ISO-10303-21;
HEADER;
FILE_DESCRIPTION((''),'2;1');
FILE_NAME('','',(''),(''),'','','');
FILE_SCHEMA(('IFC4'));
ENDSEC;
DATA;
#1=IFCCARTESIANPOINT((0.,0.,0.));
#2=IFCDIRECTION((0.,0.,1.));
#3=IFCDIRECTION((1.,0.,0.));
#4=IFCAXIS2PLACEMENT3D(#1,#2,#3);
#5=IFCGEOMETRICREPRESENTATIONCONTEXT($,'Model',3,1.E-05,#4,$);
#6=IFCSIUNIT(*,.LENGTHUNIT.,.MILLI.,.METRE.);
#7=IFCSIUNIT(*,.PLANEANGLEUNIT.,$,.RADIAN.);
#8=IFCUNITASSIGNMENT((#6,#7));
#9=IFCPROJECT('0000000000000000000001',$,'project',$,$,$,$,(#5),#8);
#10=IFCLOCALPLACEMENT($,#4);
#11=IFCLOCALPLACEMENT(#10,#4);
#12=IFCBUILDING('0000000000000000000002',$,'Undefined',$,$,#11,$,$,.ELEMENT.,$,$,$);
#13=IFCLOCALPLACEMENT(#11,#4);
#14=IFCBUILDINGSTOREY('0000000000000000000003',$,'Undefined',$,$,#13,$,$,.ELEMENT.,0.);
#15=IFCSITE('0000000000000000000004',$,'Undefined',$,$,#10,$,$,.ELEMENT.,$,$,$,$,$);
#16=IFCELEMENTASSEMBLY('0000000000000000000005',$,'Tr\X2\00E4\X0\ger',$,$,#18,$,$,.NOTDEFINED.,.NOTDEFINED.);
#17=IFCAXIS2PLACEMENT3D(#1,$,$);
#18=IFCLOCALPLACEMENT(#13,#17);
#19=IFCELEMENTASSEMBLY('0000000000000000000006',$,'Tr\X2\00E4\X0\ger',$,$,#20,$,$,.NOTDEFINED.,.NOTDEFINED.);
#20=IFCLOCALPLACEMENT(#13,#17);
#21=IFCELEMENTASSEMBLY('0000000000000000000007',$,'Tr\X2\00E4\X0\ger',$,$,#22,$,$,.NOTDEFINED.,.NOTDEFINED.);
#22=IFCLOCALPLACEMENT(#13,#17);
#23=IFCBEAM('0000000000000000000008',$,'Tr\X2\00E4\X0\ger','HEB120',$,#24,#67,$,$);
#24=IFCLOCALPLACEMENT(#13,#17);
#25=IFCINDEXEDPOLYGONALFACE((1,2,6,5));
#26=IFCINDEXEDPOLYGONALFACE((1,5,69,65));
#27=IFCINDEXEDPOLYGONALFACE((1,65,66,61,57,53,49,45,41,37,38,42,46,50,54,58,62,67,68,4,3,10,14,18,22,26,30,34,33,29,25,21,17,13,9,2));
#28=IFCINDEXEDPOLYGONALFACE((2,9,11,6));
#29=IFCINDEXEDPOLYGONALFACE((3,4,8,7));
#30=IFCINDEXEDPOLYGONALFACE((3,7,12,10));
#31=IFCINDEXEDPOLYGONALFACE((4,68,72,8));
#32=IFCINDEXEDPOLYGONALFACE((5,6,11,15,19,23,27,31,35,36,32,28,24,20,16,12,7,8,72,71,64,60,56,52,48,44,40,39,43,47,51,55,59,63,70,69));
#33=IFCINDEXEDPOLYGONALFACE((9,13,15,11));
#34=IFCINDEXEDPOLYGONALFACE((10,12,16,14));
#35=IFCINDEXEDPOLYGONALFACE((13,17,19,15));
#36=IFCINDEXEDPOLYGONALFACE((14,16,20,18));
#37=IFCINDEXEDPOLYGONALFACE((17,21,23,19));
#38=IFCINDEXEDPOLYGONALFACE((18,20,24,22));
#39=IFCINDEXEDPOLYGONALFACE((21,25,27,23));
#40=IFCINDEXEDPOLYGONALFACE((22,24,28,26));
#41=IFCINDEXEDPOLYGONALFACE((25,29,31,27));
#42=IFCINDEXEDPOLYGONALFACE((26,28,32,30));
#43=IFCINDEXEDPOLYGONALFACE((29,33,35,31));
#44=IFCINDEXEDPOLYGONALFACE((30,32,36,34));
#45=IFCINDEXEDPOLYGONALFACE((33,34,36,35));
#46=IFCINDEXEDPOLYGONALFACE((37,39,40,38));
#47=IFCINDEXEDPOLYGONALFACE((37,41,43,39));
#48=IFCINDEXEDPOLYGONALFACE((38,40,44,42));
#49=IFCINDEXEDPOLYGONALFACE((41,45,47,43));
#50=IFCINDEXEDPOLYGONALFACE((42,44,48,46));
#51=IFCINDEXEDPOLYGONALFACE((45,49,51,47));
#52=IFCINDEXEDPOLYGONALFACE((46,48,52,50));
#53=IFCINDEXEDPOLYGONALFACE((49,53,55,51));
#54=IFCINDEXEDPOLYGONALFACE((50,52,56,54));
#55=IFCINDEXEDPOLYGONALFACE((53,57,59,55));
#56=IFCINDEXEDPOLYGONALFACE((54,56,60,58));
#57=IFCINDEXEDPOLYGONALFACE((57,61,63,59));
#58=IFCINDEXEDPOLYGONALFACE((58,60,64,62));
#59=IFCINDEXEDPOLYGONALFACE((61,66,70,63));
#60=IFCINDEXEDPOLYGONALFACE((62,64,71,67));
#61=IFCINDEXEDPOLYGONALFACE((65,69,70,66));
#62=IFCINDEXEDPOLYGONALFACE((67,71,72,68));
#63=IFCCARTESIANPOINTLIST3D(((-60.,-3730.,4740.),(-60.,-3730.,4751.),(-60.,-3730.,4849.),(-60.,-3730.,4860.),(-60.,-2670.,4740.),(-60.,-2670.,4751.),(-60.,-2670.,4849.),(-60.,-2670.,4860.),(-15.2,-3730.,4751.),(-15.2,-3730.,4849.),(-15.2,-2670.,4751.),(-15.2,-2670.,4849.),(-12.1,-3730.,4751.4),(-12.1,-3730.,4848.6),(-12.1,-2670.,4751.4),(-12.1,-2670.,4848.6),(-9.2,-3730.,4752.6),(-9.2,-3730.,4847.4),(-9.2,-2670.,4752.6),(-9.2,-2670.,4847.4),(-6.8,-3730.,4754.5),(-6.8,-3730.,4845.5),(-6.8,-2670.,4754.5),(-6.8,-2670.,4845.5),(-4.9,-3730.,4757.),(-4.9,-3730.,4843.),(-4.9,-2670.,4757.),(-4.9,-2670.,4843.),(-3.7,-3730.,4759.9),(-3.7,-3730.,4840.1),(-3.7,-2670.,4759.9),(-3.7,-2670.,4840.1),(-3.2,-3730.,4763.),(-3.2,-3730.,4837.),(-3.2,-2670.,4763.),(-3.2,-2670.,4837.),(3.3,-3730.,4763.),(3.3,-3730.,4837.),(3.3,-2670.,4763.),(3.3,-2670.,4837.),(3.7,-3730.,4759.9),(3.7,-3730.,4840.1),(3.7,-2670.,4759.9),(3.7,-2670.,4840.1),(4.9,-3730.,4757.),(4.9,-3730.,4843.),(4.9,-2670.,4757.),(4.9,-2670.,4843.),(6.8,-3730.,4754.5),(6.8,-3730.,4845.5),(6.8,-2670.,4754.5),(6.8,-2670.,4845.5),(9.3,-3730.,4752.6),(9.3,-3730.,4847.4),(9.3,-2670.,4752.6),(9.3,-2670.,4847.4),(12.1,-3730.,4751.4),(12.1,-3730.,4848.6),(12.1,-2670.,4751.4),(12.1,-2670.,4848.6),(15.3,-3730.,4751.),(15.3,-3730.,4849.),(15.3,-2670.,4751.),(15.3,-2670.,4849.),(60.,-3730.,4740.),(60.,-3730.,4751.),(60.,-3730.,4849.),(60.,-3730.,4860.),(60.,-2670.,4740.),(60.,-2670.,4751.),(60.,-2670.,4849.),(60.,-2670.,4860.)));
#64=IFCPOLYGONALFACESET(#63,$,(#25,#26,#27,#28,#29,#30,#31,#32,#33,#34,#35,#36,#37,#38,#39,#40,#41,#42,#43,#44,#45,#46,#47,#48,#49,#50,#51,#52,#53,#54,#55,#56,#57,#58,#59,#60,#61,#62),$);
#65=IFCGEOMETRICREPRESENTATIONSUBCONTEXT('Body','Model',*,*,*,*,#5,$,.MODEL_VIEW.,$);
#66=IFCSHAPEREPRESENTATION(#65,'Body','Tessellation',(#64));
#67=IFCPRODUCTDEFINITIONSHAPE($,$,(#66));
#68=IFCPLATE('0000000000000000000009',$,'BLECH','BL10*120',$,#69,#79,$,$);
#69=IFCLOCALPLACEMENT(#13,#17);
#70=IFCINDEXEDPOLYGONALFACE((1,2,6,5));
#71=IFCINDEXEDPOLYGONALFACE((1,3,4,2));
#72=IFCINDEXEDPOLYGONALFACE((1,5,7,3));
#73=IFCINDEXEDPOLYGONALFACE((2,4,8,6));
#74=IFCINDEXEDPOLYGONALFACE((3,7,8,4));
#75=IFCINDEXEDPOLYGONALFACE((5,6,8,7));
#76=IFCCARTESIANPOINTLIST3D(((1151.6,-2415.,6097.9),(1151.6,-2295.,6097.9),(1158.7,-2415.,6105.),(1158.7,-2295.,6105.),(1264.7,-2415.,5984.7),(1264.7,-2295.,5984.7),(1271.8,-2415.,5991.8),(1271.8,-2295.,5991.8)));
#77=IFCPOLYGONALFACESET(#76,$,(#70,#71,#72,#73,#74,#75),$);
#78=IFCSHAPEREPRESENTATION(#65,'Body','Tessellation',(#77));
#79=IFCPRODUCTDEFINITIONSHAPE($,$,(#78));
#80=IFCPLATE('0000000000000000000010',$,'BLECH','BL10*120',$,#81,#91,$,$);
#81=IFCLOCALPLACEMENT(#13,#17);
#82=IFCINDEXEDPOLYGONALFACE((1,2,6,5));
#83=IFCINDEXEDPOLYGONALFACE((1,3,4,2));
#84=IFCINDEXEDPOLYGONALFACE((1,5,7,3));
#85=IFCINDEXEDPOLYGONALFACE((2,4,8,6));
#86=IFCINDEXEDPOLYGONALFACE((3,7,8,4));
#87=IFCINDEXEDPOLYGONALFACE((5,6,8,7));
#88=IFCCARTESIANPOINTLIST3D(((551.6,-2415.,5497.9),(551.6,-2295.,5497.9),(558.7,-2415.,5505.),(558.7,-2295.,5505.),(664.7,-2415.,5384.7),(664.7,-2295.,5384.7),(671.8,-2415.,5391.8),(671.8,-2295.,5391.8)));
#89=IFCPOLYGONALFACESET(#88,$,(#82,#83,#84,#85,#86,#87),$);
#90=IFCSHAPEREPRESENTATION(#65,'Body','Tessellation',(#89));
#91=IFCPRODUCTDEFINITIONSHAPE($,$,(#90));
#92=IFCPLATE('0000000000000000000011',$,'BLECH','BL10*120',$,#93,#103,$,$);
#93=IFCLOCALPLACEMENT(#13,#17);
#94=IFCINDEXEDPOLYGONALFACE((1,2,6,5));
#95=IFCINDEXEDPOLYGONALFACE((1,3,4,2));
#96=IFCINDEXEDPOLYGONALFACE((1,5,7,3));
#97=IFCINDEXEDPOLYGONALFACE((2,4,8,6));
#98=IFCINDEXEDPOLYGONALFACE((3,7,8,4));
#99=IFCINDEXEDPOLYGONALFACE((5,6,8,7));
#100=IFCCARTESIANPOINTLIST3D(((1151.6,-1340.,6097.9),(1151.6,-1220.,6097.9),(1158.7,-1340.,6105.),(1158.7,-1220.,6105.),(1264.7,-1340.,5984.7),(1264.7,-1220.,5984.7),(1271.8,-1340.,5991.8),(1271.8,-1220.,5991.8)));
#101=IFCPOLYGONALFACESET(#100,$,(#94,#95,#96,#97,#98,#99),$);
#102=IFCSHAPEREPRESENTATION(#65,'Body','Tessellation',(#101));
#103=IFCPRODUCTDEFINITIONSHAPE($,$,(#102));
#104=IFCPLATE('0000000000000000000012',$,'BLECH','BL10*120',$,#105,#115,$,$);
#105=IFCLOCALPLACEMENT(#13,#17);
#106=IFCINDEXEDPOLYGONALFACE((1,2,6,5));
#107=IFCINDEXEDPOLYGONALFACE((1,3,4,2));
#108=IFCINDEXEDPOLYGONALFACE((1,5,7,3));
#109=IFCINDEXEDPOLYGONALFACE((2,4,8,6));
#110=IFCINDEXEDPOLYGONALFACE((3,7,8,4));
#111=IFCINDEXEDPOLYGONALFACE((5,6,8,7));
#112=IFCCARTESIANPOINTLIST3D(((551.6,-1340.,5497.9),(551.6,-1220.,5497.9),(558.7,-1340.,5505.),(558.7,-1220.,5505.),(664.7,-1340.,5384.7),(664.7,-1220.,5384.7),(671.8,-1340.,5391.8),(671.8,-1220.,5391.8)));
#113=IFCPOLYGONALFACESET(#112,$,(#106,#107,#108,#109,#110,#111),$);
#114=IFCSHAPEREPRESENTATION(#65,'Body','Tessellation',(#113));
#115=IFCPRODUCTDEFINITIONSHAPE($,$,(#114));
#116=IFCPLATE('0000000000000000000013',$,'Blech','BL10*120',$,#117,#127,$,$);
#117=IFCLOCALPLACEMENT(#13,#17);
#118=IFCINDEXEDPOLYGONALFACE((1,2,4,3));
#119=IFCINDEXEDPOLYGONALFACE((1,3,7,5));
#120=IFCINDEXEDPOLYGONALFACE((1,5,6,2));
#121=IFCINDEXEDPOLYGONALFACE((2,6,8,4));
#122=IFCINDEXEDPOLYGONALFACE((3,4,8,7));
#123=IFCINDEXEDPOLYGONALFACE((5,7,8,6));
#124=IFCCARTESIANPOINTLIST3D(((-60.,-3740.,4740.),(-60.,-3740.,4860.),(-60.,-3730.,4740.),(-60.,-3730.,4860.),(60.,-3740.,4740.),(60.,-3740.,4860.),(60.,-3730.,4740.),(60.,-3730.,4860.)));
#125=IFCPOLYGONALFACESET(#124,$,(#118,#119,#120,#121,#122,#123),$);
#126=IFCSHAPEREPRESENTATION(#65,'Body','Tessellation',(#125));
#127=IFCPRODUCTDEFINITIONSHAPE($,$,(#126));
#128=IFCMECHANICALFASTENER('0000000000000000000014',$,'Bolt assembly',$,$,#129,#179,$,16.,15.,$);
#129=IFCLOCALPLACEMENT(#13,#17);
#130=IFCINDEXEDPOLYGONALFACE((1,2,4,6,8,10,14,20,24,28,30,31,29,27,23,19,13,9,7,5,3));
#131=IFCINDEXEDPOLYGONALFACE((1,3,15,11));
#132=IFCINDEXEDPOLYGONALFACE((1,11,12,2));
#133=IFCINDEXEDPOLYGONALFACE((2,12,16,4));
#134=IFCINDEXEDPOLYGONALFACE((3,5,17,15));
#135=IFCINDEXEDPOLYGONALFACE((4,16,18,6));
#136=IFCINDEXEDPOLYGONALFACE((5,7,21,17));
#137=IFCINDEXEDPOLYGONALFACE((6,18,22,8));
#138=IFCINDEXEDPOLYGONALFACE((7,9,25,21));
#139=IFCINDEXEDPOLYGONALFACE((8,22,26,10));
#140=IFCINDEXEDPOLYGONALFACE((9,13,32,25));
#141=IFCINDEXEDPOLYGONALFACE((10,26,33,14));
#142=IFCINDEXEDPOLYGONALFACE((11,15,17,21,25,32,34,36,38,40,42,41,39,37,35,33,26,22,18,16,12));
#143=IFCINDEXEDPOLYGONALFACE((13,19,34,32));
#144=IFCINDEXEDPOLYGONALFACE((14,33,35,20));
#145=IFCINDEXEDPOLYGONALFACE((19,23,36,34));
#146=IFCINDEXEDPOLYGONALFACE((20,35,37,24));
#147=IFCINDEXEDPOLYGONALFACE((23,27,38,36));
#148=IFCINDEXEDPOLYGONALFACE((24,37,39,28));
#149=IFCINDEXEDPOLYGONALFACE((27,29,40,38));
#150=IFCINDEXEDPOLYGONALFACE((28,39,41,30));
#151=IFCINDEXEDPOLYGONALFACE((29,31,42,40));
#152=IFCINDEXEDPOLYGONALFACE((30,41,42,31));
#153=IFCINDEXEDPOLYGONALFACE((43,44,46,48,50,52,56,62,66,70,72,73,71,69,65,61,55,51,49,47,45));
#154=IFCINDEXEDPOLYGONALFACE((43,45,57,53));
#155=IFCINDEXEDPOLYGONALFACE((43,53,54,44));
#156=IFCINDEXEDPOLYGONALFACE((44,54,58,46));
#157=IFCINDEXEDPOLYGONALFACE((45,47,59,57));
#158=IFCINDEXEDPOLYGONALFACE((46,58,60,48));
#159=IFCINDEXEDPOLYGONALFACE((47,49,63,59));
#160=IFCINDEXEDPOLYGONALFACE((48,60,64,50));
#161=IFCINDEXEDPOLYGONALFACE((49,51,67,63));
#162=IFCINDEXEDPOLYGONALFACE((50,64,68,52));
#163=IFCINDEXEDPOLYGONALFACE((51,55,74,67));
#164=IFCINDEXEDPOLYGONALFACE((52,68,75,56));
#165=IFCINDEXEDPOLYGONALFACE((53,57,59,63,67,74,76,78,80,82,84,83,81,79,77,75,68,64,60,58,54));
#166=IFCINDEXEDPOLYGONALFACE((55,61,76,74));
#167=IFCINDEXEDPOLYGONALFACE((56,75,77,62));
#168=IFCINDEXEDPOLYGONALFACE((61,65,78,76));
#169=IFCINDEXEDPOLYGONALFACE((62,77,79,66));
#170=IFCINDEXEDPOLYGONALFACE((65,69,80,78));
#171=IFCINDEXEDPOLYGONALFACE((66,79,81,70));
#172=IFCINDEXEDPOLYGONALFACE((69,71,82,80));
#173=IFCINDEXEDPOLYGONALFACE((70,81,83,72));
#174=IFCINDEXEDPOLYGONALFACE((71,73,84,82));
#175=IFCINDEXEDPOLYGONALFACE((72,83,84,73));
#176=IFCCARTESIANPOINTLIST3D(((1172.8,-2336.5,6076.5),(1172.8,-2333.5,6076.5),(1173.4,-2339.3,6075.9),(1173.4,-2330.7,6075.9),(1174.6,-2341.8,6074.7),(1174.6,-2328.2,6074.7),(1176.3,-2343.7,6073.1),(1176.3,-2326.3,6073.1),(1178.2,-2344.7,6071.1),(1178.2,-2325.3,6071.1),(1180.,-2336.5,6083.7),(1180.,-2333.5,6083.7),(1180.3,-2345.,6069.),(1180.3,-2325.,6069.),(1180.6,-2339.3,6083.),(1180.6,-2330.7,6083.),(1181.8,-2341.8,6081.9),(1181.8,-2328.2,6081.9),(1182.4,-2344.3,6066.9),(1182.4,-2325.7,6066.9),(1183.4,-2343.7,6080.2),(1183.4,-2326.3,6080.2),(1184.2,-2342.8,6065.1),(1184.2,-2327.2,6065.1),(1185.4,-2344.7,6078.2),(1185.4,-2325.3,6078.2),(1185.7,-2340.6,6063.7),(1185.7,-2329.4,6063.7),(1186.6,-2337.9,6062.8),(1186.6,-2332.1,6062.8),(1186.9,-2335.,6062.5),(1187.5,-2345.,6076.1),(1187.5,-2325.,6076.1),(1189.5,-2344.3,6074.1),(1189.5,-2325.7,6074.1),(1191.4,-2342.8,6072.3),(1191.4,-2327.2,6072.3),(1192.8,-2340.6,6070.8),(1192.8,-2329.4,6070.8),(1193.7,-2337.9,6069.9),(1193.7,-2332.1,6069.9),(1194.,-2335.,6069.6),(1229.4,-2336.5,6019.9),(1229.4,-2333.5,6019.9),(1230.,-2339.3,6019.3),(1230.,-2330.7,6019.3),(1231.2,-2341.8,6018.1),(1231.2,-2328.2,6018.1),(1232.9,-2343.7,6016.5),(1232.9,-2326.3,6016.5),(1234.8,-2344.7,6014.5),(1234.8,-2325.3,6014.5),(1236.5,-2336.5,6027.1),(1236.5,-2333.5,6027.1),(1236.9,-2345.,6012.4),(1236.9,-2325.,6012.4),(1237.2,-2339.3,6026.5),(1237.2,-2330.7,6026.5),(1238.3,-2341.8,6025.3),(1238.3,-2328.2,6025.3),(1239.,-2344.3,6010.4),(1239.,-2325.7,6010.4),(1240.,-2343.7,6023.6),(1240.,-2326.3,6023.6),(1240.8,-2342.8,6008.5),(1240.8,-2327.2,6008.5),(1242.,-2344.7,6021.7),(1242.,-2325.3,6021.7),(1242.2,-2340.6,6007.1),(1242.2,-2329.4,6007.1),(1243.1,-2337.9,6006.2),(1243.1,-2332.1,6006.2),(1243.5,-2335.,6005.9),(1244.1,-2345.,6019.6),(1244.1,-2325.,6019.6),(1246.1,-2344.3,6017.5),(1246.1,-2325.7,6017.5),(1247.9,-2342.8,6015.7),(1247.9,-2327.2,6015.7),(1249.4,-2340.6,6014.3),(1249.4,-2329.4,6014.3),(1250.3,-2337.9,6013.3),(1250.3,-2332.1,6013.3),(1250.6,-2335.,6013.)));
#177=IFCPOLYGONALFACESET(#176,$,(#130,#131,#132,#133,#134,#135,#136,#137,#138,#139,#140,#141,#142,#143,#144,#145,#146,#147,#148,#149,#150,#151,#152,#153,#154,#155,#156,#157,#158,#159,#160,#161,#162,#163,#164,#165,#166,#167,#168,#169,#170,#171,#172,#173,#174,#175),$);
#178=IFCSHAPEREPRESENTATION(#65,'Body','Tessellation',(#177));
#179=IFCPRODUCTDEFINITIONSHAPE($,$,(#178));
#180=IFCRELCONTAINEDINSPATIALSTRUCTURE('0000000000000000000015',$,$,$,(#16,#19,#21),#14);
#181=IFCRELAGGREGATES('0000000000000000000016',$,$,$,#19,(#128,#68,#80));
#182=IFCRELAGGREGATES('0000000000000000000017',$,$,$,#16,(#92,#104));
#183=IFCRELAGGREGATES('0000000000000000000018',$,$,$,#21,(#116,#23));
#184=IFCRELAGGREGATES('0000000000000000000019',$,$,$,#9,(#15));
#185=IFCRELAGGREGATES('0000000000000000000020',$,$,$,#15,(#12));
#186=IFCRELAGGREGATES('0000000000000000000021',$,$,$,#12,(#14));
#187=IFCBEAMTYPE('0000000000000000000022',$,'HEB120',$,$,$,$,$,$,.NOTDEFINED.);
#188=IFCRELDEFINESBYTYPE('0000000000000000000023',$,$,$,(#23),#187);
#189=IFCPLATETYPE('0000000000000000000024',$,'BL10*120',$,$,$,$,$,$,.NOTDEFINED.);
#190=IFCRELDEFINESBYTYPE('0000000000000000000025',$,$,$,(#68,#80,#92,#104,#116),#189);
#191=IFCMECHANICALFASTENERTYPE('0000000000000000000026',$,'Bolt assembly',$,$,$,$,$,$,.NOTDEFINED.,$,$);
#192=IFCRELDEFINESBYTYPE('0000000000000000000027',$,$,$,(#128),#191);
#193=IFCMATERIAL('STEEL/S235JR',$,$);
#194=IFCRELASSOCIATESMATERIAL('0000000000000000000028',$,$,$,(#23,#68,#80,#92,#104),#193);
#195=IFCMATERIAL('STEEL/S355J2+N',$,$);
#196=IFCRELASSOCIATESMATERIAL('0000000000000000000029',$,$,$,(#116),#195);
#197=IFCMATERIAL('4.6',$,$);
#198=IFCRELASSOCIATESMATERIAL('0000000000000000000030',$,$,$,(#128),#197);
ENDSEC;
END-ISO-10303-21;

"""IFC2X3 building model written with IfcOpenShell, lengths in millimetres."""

from ifc_helpers import new_model, si_unit, frame, origin_with_axes, origin_2d_with_axis, place, context, subcontext, project, spatial, polyline, circle, i_section, outline, extrude, clip, halfspace, source, transform, mapped, material, type_object, element, aggregate, save


model = new_model("IFC2X3")

# Units and contexts
model_context = context("Model", 3, precision=1e-05, world=origin_with_axes())
body_context = subcontext(model_context, "Body", "Model", "MODEL_VIEW")
ifc_project = project(units=[si_unit("LENGTHUNIT", "METRE", prefix="MILLI"), si_unit("PLANEANGLEUNIT", "RADIAN")], contexts=[model_context])

# Site, building, storey
site_placement = place(None, origin_with_axes())
site = spatial("IfcSite", under=ifc_project, at=site_placement, Name="Undefined", CompositionType="ELEMENT")
building_placement = place(site_placement, origin_with_axes())
building = spatial("IfcBuilding", under=site, at=building_placement, Name="Undefined", CompositionType="ELEMENT")
storey_placement = place(building_placement, origin_with_axes())
storey = spatial("IfcBuildingStorey", under=building, at=storey_placement, Name="Undefined", CompositionType="ELEMENT", Elevation=0.0)

# Element assemblies, beam
assembly_1_placement = place(storey_placement, origin_with_axes())
assembly_1 = element("IfcElementAssembly", 1, at=assembly_1_placement, inside=storey, Name="Träger", AssemblyPlace="NOTDEFINED", PredefinedType="NOTDEFINED")
ifc_material_1 = material(Name="STEEL/S235JR")
assembly_2_placement = place(storey_placement, origin_with_axes())
assembly_2 = element("IfcElementAssembly", 2, at=assembly_2_placement, inside=storey, Name="Träger", AssemblyPlace="NOTDEFINED", PredefinedType="NOTDEFINED")
beam_type_1 = type_object("IfcBeamType", Name="HEB120", PredefinedType="NOTDEFINED")
assembly_3_placement = place(storey_placement, origin_with_axes())
assembly_3 = element("IfcElementAssembly", 3, at=assembly_3_placement, inside=storey, Name="Träger", AssemblyPlace="NOTDEFINED", PredefinedType="NOTDEFINED")
beam_1_placement = place(assembly_3_placement, frame((0.0, -2670.0, 4800.0), z_axis=(0.0, 0.0, 1.0), x_axis=(0.0, -1.0, 0.0)))
beam_1 = element("IfcBeam", 4, at=beam_1_placement, type_object=beam_type_1, material=ifc_material_1, Name="Träger", Description="HEB120", context=body_context, shape_type="Clipping", body=[
    clip(clip(extrude(i_section(OverallWidth=120.0, OverallDepth=120.0, WebThickness=6.5, FlangeThickness=11.0, FilletRadius=12.0, at=origin_2d_with_axis()), frame((1060.0, 0.0, 0.0), z_axis=(-1.0, 0.0, 0.0), x_axis=(0.0, -1.0, 0.0)), (0.0, 0.0, 1.0), 1060.0), halfspace(frame((1060.0, 0.0, -60.0), z_axis=(-1.0, 0.0, 0.0), x_axis=(0.0, 1.0, 0.0)), True)), halfspace(frame((0.0, 0.0, -60.0), z_axis=(1.0, 0.0, 0.0), x_axis=(0.0, -1.0, 0.0)), True)),
])

# Plates
plate_type_1 = type_object("IfcPlateType", Name="BL10*120", PredefinedType="NOTDEFINED")
plate_1_placement = place(assembly_2_placement, frame((1268.3, -2295.0, 5988.3), z_axis=(-0.707107, 0.0, -0.707107), x_axis=(0.0, -1.0, 0.0)))
plate_1 = element("IfcPlate", 5, at=plate_1_placement, type_object=plate_type_1, material=ifc_material_1, Name="BLECH", Description="BL10*120", context=body_context, shape_type="SweptSolid", body=[
    extrude(outline(polyline([(0.0, 0.0), (120.0, 0.0), (120.0, 160.0), (0.0, 160.0), (0.0, 0.0)])), frame((0.0, 0.0, -5.0), z_axis=(0.0, 0.0, 1.0), x_axis=(1.0, 0.0, 0.0)), (0.0, 0.0, 1.0), 10.0),
])
plate_2_placement = place(assembly_2_placement, frame((668.3, -2295.0, 5388.3), z_axis=(-0.707107, 0.0, -0.707107), x_axis=(0.0, -1.0, 0.0)))
plate_2 = element("IfcPlate", 6, at=plate_2_placement, type_object=plate_type_1, material=ifc_material_1, Name="BLECH", Description="BL10*120", context=body_context, shape_type="SweptSolid", body=[
    extrude(outline(polyline([(0.0, 0.0), (120.0, 0.0), (120.0, 160.0), (0.0, 160.0), (0.0, 0.0)])), frame((0.0, 0.0, -5.0), z_axis=(0.0, 0.0, 1.0), x_axis=(1.0, 0.0, 0.0)), (0.0, 0.0, 1.0), 10.0),
])
plate_3_placement = place(assembly_1_placement, frame((1268.3, -1340.0, 5988.3), z_axis=(0.707107, 0.0, 0.707107), x_axis=(0.0, 1.0, 0.0)))
plate_3 = element("IfcPlate", 7, at=plate_3_placement, type_object=plate_type_1, material=ifc_material_1, Name="BLECH", Description="BL10*120", context=body_context, shape_type="SweptSolid", body=[
    extrude(outline(polyline([(0.0, 0.0), (120.0, 0.0), (120.0, 160.0), (0.0, 160.0), (0.0, 0.0)])), frame((0.0, 0.0, -5.0), z_axis=(0.0, 0.0, 1.0), x_axis=(1.0, 0.0, 0.0)), (0.0, 0.0, 1.0), 10.0),
])
plate_4_placement = place(assembly_1_placement, frame((668.3, -1340.0, 5388.3), z_axis=(0.707107, 0.0, 0.707107), x_axis=(0.0, 1.0, 0.0)))
plate_4 = element("IfcPlate", 8, at=plate_4_placement, type_object=plate_type_1, material=ifc_material_1, Name="BLECH", Description="BL10*120", context=body_context, shape_type="SweptSolid", body=[
    extrude(outline(polyline([(0.0, 0.0), (120.0, 0.0), (120.0, 160.0), (0.0, 160.0), (0.0, 0.0)])), frame((0.0, 0.0, -5.0), z_axis=(0.0, 0.0, 1.0), x_axis=(1.0, 0.0, 0.0)), (0.0, 0.0, 1.0), 10.0),
])
ifc_material_2 = material(Name="STEEL/S355J2+N")
plate_5_placement = place(assembly_3_placement, frame((0.0, -3735.0, 4740.0), z_axis=(0.0, 1.0, 0.0), x_axis=(0.0, 0.0, 1.0)))
plate_5 = element("IfcPlate", 9, at=plate_5_placement, type_object=plate_type_1, material=ifc_material_2, Name="Blech", Description="BL10*120", context=body_context, shape_type="SweptSolid", body=[
    extrude(outline(polyline([(0.0, -60.0), (0.0, 60.0), (120.0, 60.0), (120.0, -60.0), (0.0, -60.0)])), frame((0.0, 0.0, -5.0), z_axis=(0.0, 0.0, 1.0), x_axis=(1.0, 0.0, 0.0)), (0.0, 0.0, 1.0), 10.0),
])

# Mechanical fastener
ifc_material_3 = material(Name="4.6")
mechanical_fastener_type = type_object("IfcMechanicalFastenerType", Name="Bolt assembly")
shared_shape_1 = source(origin_with_axes(), body_context, "Body", "SweptSolid", [
    extrude(circle(Radius=10.0, at=origin_2d_with_axis()), frame((0.0, 0.0, 0.0), z_axis=(0.0, 1.0, 0.0), x_axis=(1.0, 0.0, 0.0)), (0.0, 0.0, 1.0), 10.1),
])
mechanical_fastener_1_placement = place(assembly_2_placement, frame((1187.0, -2335.0, 6076.7), z_axis=(0.0, 1.0, 0.0), x_axis=(0.707107, 0.0, -0.707107)))
mechanical_fastener_1 = element("IfcMechanicalFastener", 10, at=mechanical_fastener_1_placement, type_object=mechanical_fastener_type, material=ifc_material_3, Name="Bolt assembly", NominalDiameter=16.0, NominalLength=15.0, context=body_context, shape_type="MappedRepresentation", body=[
    mapped(shared_shape_1, transform((0.0, 0.0, 0.0))),
    mapped(shared_shape_1, transform((80.0, 0.0, 0.0))),
])
aggregate(assembly_2, [mechanical_fastener_1, plate_1, plate_2])
aggregate(assembly_1, [plate_3, plate_4])
aggregate(assembly_3, [plate_5, beam_1])

save(model, "model.ifc")
